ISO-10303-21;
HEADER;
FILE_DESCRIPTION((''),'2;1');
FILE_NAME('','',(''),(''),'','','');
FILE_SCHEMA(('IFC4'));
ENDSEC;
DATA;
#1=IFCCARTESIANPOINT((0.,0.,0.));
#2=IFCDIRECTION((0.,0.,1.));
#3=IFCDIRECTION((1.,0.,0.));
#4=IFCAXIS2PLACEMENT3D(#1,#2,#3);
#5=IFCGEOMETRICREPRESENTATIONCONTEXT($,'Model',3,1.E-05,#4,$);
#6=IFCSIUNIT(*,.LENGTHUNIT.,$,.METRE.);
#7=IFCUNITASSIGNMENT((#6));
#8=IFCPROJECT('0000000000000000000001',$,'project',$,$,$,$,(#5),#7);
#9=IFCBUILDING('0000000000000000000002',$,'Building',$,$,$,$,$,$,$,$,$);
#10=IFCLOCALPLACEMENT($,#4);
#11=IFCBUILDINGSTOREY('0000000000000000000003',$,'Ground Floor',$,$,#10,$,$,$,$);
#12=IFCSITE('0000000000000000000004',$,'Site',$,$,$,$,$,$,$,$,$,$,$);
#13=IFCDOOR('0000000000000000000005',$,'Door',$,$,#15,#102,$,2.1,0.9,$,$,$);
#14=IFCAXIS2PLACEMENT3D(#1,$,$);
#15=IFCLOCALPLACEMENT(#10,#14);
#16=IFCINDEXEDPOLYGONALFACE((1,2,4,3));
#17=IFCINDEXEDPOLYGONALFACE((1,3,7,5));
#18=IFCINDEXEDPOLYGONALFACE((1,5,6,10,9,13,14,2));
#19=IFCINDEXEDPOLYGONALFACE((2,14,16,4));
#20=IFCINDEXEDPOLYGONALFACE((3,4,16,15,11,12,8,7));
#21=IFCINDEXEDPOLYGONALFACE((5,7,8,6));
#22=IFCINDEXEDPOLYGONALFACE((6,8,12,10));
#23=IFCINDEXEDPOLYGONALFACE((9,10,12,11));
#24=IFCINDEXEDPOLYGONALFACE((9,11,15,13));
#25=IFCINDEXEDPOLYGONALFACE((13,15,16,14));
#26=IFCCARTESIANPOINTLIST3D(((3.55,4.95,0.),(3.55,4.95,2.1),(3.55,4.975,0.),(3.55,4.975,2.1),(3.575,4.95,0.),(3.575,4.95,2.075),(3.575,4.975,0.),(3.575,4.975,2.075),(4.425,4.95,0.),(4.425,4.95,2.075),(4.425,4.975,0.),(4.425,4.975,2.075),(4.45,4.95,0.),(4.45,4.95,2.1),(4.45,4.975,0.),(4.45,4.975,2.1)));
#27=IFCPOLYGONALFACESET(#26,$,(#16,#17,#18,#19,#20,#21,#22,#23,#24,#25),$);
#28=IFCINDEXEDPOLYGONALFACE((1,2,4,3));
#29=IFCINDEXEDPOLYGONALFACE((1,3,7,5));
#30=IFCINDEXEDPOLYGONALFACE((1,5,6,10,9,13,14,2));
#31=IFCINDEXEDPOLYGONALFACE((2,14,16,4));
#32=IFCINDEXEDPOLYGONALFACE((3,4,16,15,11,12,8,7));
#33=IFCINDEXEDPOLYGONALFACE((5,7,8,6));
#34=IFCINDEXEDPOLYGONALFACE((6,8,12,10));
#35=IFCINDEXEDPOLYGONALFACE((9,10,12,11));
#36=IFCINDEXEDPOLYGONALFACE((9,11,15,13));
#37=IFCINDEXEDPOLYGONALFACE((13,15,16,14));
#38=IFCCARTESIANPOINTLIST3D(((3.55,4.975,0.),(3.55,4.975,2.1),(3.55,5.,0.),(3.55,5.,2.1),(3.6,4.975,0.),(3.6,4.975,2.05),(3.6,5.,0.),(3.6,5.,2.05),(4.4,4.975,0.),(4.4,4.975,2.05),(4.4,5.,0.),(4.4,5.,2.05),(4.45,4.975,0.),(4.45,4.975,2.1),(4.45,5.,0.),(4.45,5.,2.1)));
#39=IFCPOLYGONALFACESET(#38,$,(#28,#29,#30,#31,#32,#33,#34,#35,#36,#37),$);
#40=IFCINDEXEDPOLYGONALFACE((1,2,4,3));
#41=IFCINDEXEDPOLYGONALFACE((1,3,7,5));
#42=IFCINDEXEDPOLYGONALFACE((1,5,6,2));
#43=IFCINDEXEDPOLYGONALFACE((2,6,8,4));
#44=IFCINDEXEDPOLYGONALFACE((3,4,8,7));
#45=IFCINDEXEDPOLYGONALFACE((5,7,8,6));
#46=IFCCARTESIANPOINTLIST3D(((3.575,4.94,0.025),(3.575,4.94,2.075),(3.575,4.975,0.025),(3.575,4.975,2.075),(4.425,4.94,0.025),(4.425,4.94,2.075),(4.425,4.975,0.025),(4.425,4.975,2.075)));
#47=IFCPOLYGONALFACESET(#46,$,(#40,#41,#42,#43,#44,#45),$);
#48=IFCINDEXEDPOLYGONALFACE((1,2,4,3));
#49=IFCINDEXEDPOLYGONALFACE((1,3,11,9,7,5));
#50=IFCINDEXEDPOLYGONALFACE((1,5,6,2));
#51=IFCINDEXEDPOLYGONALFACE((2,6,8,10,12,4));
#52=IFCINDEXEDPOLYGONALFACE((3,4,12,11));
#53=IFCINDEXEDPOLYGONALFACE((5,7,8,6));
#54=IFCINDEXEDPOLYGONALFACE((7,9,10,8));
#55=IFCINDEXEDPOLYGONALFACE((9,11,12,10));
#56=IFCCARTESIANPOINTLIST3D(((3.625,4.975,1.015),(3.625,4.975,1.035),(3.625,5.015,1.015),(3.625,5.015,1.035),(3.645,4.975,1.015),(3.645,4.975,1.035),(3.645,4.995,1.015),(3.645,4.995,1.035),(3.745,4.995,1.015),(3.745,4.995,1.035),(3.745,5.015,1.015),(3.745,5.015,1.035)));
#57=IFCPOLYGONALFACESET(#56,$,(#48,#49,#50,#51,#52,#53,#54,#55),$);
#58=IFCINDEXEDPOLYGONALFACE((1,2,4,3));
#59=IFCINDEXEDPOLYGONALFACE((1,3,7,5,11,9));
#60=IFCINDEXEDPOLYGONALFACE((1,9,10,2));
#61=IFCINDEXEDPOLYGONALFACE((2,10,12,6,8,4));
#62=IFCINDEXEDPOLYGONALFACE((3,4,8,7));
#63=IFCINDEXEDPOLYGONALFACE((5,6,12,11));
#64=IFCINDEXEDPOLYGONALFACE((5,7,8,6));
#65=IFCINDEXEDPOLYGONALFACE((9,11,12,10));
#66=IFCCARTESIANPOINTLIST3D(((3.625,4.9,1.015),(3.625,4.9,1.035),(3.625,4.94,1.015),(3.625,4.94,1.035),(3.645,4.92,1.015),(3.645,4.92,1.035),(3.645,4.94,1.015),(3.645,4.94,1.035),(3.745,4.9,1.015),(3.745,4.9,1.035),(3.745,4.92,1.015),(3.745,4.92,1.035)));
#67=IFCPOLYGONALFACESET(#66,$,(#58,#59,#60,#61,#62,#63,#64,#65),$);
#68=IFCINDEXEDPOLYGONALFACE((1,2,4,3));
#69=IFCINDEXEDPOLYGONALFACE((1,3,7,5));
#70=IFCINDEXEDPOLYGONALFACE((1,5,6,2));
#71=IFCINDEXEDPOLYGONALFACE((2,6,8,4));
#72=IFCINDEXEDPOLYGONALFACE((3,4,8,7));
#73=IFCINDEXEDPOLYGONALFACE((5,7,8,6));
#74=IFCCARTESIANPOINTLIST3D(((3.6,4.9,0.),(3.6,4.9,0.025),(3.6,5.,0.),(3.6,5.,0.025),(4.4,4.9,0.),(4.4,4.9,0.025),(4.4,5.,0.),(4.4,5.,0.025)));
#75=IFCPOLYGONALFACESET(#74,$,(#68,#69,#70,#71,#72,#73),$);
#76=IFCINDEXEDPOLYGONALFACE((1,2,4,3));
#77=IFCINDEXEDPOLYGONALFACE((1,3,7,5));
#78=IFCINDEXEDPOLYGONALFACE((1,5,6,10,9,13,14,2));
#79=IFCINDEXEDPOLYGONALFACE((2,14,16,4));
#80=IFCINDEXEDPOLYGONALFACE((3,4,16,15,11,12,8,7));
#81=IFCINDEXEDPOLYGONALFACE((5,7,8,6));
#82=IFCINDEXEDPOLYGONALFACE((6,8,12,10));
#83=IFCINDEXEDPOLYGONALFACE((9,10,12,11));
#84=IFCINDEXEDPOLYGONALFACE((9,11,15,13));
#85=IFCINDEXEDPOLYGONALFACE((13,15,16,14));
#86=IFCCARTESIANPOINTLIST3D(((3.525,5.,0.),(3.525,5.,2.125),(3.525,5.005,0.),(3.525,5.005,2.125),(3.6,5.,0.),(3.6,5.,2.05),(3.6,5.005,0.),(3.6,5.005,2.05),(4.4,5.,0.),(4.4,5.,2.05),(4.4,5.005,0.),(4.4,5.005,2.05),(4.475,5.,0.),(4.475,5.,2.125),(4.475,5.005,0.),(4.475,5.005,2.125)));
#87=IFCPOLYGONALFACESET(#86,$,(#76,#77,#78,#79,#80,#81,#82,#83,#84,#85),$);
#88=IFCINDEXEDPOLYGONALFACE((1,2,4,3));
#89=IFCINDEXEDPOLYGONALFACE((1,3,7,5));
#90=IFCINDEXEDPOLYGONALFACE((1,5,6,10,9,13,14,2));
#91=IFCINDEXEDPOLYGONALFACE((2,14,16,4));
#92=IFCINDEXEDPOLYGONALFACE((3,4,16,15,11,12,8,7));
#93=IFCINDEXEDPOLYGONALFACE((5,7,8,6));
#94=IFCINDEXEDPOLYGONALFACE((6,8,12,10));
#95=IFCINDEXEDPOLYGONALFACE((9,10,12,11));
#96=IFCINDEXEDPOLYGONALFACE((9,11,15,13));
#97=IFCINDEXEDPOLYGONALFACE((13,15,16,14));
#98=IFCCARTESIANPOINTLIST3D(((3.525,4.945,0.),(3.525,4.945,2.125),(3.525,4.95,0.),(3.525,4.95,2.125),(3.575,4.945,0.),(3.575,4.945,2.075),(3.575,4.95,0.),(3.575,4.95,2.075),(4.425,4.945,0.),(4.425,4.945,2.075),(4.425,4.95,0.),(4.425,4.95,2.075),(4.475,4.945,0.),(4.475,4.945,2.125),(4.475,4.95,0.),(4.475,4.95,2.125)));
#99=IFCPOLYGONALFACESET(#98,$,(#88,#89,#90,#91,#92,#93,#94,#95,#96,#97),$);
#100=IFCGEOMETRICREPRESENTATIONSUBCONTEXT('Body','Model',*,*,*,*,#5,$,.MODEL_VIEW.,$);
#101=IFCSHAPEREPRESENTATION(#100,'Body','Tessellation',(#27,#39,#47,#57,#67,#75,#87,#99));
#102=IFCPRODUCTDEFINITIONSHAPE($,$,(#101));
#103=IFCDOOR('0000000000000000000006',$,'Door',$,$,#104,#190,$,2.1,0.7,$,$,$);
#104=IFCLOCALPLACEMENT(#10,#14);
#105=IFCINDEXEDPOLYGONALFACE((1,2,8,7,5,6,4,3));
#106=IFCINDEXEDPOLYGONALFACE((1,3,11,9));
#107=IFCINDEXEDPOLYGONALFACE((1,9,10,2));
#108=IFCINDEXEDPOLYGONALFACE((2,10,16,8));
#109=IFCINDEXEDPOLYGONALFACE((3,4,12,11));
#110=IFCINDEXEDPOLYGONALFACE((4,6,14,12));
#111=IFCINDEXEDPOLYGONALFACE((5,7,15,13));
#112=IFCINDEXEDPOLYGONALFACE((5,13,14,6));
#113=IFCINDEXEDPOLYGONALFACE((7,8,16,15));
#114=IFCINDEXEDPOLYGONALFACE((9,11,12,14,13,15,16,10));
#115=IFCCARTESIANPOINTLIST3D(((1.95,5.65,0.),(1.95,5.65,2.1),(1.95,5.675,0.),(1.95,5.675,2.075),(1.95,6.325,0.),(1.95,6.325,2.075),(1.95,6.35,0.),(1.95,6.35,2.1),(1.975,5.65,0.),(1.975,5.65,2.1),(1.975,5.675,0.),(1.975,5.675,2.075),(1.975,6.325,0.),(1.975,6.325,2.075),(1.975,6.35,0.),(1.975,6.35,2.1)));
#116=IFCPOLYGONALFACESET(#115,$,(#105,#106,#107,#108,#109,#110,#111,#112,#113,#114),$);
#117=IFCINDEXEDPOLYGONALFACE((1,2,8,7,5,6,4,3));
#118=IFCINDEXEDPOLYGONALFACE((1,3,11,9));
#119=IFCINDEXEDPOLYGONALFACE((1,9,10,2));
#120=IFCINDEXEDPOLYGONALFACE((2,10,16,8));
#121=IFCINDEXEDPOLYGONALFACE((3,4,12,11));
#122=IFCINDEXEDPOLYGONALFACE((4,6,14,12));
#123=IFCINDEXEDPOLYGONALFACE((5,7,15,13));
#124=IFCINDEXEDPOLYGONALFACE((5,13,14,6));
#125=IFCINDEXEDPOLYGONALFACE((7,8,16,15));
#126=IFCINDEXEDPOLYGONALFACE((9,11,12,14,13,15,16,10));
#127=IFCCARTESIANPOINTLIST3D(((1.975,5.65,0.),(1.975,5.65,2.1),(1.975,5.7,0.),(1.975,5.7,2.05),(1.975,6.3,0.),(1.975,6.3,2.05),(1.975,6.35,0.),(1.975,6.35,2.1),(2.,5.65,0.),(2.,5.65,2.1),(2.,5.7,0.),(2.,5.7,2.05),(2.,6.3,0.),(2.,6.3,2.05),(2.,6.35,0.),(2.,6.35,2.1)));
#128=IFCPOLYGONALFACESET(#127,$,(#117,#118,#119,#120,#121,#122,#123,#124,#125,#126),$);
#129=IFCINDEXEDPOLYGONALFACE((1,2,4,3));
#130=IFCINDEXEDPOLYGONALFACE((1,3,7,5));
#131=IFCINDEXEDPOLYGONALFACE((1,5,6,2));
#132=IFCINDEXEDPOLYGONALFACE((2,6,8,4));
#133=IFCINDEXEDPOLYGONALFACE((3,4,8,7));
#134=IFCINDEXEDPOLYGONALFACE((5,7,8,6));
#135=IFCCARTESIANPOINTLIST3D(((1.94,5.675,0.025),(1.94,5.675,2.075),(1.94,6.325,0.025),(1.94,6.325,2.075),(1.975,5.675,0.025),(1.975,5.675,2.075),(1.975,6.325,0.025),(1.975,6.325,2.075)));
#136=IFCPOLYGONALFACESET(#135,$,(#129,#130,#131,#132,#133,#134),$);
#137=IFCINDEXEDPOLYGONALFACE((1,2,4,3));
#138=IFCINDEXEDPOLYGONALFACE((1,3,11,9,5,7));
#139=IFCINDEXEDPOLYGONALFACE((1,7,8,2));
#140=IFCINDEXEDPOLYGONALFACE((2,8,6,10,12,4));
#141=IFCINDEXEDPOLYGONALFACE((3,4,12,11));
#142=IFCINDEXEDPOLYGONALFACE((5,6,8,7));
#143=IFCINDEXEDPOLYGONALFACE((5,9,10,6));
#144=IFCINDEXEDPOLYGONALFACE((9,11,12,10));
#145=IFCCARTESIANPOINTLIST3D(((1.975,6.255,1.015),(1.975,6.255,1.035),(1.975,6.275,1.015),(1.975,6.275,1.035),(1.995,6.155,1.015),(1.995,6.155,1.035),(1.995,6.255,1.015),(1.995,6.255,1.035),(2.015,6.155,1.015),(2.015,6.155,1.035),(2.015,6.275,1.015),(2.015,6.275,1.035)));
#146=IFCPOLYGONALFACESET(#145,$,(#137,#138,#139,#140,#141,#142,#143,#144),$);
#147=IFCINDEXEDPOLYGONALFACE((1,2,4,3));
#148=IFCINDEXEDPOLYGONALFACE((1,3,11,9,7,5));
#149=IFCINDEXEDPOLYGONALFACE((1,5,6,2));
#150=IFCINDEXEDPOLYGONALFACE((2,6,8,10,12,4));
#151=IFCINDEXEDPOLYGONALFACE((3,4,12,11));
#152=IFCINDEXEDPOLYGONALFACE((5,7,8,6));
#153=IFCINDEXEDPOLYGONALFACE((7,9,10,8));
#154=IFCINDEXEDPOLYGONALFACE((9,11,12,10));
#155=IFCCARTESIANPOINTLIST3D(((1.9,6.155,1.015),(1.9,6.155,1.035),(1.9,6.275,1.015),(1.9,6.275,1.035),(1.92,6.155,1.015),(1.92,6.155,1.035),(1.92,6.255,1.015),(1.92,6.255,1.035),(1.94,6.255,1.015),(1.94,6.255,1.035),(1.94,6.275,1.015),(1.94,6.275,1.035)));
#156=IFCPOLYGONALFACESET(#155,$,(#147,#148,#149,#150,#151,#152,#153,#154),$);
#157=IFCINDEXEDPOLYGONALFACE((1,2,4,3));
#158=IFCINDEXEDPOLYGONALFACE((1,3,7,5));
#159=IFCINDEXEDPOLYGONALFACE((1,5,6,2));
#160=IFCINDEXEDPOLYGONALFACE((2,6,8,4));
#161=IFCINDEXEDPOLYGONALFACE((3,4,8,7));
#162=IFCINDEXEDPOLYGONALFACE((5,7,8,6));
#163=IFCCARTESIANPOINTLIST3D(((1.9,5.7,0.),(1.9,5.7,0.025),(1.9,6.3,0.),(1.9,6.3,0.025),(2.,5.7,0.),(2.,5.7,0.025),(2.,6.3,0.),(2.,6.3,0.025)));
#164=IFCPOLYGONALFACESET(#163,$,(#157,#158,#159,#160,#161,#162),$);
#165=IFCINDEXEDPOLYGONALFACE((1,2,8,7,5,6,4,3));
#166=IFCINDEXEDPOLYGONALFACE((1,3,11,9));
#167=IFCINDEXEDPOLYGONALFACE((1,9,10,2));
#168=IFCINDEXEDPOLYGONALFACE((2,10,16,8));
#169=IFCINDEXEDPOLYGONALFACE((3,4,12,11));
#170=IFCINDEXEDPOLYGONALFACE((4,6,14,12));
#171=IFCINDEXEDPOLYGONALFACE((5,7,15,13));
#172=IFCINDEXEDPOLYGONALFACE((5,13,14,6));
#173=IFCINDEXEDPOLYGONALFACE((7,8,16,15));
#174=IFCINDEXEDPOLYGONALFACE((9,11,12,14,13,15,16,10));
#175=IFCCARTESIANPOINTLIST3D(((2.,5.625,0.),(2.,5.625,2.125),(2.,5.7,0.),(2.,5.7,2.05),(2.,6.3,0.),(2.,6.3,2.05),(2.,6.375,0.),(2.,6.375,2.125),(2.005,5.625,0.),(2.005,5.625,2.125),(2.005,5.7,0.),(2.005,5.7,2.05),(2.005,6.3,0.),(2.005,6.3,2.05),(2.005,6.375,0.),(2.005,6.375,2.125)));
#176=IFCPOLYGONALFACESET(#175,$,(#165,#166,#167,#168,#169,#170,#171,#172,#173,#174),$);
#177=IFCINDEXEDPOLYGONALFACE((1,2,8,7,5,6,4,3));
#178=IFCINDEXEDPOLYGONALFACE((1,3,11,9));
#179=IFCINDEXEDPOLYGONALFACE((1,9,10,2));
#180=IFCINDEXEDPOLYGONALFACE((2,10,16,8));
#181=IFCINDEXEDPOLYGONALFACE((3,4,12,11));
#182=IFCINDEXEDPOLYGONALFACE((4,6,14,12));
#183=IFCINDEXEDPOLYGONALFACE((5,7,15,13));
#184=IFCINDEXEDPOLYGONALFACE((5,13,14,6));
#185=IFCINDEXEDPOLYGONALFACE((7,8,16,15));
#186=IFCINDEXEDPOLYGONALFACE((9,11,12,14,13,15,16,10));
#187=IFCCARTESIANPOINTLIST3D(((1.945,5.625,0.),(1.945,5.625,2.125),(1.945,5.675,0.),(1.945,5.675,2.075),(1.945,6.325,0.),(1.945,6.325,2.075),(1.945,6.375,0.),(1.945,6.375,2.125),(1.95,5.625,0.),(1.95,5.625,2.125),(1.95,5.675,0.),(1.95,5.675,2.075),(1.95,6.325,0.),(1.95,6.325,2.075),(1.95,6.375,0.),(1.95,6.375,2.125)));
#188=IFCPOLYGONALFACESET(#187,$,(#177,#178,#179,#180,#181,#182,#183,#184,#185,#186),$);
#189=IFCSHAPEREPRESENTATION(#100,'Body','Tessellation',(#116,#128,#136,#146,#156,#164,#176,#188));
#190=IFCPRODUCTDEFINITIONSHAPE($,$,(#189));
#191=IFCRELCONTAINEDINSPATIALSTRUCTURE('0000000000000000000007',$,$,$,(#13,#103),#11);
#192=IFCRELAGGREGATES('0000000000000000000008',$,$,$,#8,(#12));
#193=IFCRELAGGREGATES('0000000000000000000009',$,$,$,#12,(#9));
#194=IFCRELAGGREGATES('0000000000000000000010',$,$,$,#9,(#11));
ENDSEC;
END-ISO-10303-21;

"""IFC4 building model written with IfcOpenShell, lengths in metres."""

from ifc_helpers import new_model, si_unit, frame, origin_with_axes, place, context, subcontext, project, spatial, line, indexed_curve, outline, extrude, element, save


model = new_model("IFC4")

# Units and contexts
model_context = context("Model", 3, precision=1e-05, world=origin_with_axes())
body_context = subcontext(model_context, "Body", "Model", "MODEL_VIEW")
ifc_project = project(units=[si_unit("LENGTHUNIT", "METRE")], contexts=[model_context])

# Site, building, storey
site = spatial("IfcSite", under=ifc_project, Name="Site")
building = spatial("IfcBuilding", under=site, Name="Building")
storey_placement = place(None, origin_with_axes())
storey = spatial("IfcBuildingStorey", under=building, at=storey_placement, Name="Ground Floor")

# Doors
door_1_placement = place(storey_placement, frame((4.45, 5.0, 0.0), z_axis=(0.0, 0.0, 1.0), x_axis=(-1.0, 0.0, 0.0)))
element("IfcDoor", 1, at=door_1_placement, inside=storey, Name="Door", OverallHeight=2.1, OverallWidth=0.9, context=body_context, shape_type="SweptSolid", body=[
    extrude(outline(indexed_curve([(0.0, 0.0), (0.0, 2.1), (0.9, 2.1), (0.9, 0.0), (0.875, 0.0), (0.875, 2.075), (0.025, 2.075), (0.025, 0.0)], segments=[line(1, 2, 3, 4, 5, 6, 7, 8, 1)])), frame((0.0, 0.025, 0.0), z_axis=(0.0, -1.0, 0.0), x_axis=(1.0, 0.0, 0.0)), (0.0, 0.0, -1.0), 0.025),
    extrude(outline(indexed_curve([(0.0, 0.0), (0.0, 2.1), (0.9, 2.1), (0.9, 0.0), (0.85, 0.0), (0.85, 2.05), (0.05, 2.05), (0.05, 0.0)], segments=[line(1, 2, 3, 4, 5, 6, 7, 8, 1)])), frame((0.0, 0.0, 0.0), z_axis=(0.0, -1.0, 0.0), x_axis=(1.0, 0.0, 0.0)), (0.0, 0.0, -1.0), 0.025),
    extrude(outline(indexed_curve([(0.0, 0.0), (0.85, 0.0), (0.85, 0.035), (0.0, 0.035)], segments=[line(1, 2, 3, 4, 1)])), frame((0.025, 0.025, 0.025), z_axis=(0.0, 0.0, 1.0), x_axis=(1.0, 0.0, 0.0)), (0.0, 0.0, 1.0), 2.05),
    extrude(outline(indexed_curve([(0.0, 0.0), (0.0, -0.04), (-0.12, -0.04), (-0.12, -0.02), (-0.02, -0.02), (-0.02, 0.0)], segments=[line(1, 2, 3, 4, 5, 6, 1)])), frame((0.825, 0.025, 1.015), z_axis=(0.0, 0.0, 1.0), x_axis=(1.0, 0.0, 0.0)), (0.0, 0.0, 1.0), 0.02),
    extrude(outline(indexed_curve([(0.0, 0.0), (0.0, 0.04), (-0.12, 0.04), (-0.12, 0.02), (-0.02, 0.02), (-0.02, 0.0)], segments=[line(1, 2, 3, 4, 5, 6, 1)])), frame((0.825, 0.06, 1.015), z_axis=(0.0, 0.0, 1.0), x_axis=(1.0, 0.0, 0.0)), (0.0, 0.0, 1.0), 0.02),
    extrude(outline(indexed_curve([(0.0, 0.0), (0.8, 0.0), (0.8, 0.1), (0.0, 0.1)], segments=[line(1, 2, 3, 4, 1)])), frame((0.05, 0.0, 0.0), z_axis=(0.0, 0.0, 1.0), x_axis=(1.0, 0.0, 0.0)), (0.0, 0.0, 1.0), 0.025),
    extrude(outline(indexed_curve([(0.0, 0.0), (0.0, 2.125), (0.95, 2.125), (0.95, 0.0), (0.875, 0.0), (0.875, 2.05), (0.075, 2.05), (0.075, 0.0)], segments=[line(1, 2, 3, 4, 5, 6, 7, 8, 1)])), frame((-0.025, -0.005, 0.0), z_axis=(0.0, -1.0, 0.0), x_axis=(1.0, 0.0, 0.0)), (0.0, 0.0, -1.0), 0.005),
    extrude(outline(indexed_curve([(0.0, 0.0), (0.0, 2.125), (0.95, 2.125), (0.95, 0.0), (0.9, 0.0), (0.9, 2.075), (0.05, 2.075), (0.05, 0.0)], segments=[line(1, 2, 3, 4, 5, 6, 7, 8, 1)])), frame((-0.025, 0.05, 0.0), z_axis=(0.0, -1.0, 0.0), x_axis=(1.0, 0.0, 0.0)), (0.0, 0.0, -1.0), 0.005),
])
door_2_placement = place(storey_placement, frame((2.0, 5.65, 0.0), z_axis=(0.0, 0.0, 1.0), x_axis=(0.0, 1.0, 0.0)))
element("IfcDoor", 2, at=door_2_placement, inside=storey, Name="Door", OverallHeight=2.1, OverallWidth=0.7, context=body_context, shape_type="SweptSolid", body=[
    extrude(outline(indexed_curve([(0.0, 0.0), (0.0, 2.1), (0.7, 2.1), (0.7, 0.0), (0.675, 0.0), (0.675, 2.075), (0.025, 2.075), (0.025, 0.0)], segments=[line(1, 2, 3, 4, 5, 6, 7, 8, 1)])), frame((0.0, 0.025, 0.0), z_axis=(0.0, -1.0, 0.0), x_axis=(1.0, 0.0, 0.0)), (0.0, 0.0, -1.0), 0.025),
    extrude(outline(indexed_curve([(0.0, 0.0), (0.0, 2.1), (0.7, 2.1), (0.7, 0.0), (0.65, 0.0), (0.65, 2.05), (0.05, 2.05), (0.05, 0.0)], segments=[line(1, 2, 3, 4, 5, 6, 7, 8, 1)])), frame((0.0, 0.0, 0.0), z_axis=(0.0, -1.0, 0.0), x_axis=(1.0, 0.0, 0.0)), (0.0, 0.0, -1.0), 0.025),
    extrude(outline(indexed_curve([(0.0, 0.0), (0.65, 0.0), (0.65, 0.035), (0.0, 0.035)], segments=[line(1, 2, 3, 4, 1)])), frame((0.025, 0.025, 0.025), z_axis=(0.0, 0.0, 1.0), x_axis=(1.0, 0.0, 0.0)), (0.0, 0.0, 1.0), 2.05),
    extrude(outline(indexed_curve([(0.0, 0.0), (0.0, -0.04), (-0.12, -0.04), (-0.12, -0.02), (-0.02, -0.02), (-0.02, 0.0)], segments=[line(1, 2, 3, 4, 5, 6, 1)])), frame((0.625, 0.025, 1.015), z_axis=(0.0, 0.0, 1.0), x_axis=(1.0, 0.0, 0.0)), (0.0, 0.0, 1.0), 0.02),
    extrude(outline(indexed_curve([(0.0, 0.0), (0.0, 0.04), (-0.12, 0.04), (-0.12, 0.02), (-0.02, 0.02), (-0.02, 0.0)], segments=[line(1, 2, 3, 4, 5, 6, 1)])), frame((0.625, 0.06, 1.015), z_axis=(0.0, 0.0, 1.0), x_axis=(1.0, 0.0, 0.0)), (0.0, 0.0, 1.0), 0.02),
    extrude(outline(indexed_curve([(0.0, 0.0), (0.6, 0.0), (0.6, 0.1), (0.0, 0.1)], segments=[line(1, 2, 3, 4, 1)])), frame((0.05, 0.0, 0.0), z_axis=(0.0, 0.0, 1.0), x_axis=(1.0, 0.0, 0.0)), (0.0, 0.0, 1.0), 0.025),
    extrude(outline(indexed_curve([(0.0, 0.0), (0.0, 2.125), (0.75, 2.125), (0.75, 0.0), (0.675, 0.0), (0.675, 2.05), (0.075, 2.05), (0.075, 0.0)], segments=[line(1, 2, 3, 4, 5, 6, 7, 8, 1)])), frame((-0.025, -0.005, 0.0), z_axis=(0.0, -1.0, 0.0), x_axis=(1.0, 0.0, 0.0)), (0.0, 0.0, -1.0), 0.005),
    extrude(outline(indexed_curve([(0.0, 0.0), (0.0, 2.125), (0.75, 2.125), (0.75, 0.0), (0.7, 0.0), (0.7, 2.075), (0.05, 2.075), (0.05, 0.0)], segments=[line(1, 2, 3, 4, 5, 6, 7, 8, 1)])), frame((-0.025, 0.05, 0.0), z_axis=(0.0, -1.0, 0.0), x_axis=(1.0, 0.0, 0.0)), (0.0, 0.0, -1.0), 0.005),
])

save(model, "model.ifc")
